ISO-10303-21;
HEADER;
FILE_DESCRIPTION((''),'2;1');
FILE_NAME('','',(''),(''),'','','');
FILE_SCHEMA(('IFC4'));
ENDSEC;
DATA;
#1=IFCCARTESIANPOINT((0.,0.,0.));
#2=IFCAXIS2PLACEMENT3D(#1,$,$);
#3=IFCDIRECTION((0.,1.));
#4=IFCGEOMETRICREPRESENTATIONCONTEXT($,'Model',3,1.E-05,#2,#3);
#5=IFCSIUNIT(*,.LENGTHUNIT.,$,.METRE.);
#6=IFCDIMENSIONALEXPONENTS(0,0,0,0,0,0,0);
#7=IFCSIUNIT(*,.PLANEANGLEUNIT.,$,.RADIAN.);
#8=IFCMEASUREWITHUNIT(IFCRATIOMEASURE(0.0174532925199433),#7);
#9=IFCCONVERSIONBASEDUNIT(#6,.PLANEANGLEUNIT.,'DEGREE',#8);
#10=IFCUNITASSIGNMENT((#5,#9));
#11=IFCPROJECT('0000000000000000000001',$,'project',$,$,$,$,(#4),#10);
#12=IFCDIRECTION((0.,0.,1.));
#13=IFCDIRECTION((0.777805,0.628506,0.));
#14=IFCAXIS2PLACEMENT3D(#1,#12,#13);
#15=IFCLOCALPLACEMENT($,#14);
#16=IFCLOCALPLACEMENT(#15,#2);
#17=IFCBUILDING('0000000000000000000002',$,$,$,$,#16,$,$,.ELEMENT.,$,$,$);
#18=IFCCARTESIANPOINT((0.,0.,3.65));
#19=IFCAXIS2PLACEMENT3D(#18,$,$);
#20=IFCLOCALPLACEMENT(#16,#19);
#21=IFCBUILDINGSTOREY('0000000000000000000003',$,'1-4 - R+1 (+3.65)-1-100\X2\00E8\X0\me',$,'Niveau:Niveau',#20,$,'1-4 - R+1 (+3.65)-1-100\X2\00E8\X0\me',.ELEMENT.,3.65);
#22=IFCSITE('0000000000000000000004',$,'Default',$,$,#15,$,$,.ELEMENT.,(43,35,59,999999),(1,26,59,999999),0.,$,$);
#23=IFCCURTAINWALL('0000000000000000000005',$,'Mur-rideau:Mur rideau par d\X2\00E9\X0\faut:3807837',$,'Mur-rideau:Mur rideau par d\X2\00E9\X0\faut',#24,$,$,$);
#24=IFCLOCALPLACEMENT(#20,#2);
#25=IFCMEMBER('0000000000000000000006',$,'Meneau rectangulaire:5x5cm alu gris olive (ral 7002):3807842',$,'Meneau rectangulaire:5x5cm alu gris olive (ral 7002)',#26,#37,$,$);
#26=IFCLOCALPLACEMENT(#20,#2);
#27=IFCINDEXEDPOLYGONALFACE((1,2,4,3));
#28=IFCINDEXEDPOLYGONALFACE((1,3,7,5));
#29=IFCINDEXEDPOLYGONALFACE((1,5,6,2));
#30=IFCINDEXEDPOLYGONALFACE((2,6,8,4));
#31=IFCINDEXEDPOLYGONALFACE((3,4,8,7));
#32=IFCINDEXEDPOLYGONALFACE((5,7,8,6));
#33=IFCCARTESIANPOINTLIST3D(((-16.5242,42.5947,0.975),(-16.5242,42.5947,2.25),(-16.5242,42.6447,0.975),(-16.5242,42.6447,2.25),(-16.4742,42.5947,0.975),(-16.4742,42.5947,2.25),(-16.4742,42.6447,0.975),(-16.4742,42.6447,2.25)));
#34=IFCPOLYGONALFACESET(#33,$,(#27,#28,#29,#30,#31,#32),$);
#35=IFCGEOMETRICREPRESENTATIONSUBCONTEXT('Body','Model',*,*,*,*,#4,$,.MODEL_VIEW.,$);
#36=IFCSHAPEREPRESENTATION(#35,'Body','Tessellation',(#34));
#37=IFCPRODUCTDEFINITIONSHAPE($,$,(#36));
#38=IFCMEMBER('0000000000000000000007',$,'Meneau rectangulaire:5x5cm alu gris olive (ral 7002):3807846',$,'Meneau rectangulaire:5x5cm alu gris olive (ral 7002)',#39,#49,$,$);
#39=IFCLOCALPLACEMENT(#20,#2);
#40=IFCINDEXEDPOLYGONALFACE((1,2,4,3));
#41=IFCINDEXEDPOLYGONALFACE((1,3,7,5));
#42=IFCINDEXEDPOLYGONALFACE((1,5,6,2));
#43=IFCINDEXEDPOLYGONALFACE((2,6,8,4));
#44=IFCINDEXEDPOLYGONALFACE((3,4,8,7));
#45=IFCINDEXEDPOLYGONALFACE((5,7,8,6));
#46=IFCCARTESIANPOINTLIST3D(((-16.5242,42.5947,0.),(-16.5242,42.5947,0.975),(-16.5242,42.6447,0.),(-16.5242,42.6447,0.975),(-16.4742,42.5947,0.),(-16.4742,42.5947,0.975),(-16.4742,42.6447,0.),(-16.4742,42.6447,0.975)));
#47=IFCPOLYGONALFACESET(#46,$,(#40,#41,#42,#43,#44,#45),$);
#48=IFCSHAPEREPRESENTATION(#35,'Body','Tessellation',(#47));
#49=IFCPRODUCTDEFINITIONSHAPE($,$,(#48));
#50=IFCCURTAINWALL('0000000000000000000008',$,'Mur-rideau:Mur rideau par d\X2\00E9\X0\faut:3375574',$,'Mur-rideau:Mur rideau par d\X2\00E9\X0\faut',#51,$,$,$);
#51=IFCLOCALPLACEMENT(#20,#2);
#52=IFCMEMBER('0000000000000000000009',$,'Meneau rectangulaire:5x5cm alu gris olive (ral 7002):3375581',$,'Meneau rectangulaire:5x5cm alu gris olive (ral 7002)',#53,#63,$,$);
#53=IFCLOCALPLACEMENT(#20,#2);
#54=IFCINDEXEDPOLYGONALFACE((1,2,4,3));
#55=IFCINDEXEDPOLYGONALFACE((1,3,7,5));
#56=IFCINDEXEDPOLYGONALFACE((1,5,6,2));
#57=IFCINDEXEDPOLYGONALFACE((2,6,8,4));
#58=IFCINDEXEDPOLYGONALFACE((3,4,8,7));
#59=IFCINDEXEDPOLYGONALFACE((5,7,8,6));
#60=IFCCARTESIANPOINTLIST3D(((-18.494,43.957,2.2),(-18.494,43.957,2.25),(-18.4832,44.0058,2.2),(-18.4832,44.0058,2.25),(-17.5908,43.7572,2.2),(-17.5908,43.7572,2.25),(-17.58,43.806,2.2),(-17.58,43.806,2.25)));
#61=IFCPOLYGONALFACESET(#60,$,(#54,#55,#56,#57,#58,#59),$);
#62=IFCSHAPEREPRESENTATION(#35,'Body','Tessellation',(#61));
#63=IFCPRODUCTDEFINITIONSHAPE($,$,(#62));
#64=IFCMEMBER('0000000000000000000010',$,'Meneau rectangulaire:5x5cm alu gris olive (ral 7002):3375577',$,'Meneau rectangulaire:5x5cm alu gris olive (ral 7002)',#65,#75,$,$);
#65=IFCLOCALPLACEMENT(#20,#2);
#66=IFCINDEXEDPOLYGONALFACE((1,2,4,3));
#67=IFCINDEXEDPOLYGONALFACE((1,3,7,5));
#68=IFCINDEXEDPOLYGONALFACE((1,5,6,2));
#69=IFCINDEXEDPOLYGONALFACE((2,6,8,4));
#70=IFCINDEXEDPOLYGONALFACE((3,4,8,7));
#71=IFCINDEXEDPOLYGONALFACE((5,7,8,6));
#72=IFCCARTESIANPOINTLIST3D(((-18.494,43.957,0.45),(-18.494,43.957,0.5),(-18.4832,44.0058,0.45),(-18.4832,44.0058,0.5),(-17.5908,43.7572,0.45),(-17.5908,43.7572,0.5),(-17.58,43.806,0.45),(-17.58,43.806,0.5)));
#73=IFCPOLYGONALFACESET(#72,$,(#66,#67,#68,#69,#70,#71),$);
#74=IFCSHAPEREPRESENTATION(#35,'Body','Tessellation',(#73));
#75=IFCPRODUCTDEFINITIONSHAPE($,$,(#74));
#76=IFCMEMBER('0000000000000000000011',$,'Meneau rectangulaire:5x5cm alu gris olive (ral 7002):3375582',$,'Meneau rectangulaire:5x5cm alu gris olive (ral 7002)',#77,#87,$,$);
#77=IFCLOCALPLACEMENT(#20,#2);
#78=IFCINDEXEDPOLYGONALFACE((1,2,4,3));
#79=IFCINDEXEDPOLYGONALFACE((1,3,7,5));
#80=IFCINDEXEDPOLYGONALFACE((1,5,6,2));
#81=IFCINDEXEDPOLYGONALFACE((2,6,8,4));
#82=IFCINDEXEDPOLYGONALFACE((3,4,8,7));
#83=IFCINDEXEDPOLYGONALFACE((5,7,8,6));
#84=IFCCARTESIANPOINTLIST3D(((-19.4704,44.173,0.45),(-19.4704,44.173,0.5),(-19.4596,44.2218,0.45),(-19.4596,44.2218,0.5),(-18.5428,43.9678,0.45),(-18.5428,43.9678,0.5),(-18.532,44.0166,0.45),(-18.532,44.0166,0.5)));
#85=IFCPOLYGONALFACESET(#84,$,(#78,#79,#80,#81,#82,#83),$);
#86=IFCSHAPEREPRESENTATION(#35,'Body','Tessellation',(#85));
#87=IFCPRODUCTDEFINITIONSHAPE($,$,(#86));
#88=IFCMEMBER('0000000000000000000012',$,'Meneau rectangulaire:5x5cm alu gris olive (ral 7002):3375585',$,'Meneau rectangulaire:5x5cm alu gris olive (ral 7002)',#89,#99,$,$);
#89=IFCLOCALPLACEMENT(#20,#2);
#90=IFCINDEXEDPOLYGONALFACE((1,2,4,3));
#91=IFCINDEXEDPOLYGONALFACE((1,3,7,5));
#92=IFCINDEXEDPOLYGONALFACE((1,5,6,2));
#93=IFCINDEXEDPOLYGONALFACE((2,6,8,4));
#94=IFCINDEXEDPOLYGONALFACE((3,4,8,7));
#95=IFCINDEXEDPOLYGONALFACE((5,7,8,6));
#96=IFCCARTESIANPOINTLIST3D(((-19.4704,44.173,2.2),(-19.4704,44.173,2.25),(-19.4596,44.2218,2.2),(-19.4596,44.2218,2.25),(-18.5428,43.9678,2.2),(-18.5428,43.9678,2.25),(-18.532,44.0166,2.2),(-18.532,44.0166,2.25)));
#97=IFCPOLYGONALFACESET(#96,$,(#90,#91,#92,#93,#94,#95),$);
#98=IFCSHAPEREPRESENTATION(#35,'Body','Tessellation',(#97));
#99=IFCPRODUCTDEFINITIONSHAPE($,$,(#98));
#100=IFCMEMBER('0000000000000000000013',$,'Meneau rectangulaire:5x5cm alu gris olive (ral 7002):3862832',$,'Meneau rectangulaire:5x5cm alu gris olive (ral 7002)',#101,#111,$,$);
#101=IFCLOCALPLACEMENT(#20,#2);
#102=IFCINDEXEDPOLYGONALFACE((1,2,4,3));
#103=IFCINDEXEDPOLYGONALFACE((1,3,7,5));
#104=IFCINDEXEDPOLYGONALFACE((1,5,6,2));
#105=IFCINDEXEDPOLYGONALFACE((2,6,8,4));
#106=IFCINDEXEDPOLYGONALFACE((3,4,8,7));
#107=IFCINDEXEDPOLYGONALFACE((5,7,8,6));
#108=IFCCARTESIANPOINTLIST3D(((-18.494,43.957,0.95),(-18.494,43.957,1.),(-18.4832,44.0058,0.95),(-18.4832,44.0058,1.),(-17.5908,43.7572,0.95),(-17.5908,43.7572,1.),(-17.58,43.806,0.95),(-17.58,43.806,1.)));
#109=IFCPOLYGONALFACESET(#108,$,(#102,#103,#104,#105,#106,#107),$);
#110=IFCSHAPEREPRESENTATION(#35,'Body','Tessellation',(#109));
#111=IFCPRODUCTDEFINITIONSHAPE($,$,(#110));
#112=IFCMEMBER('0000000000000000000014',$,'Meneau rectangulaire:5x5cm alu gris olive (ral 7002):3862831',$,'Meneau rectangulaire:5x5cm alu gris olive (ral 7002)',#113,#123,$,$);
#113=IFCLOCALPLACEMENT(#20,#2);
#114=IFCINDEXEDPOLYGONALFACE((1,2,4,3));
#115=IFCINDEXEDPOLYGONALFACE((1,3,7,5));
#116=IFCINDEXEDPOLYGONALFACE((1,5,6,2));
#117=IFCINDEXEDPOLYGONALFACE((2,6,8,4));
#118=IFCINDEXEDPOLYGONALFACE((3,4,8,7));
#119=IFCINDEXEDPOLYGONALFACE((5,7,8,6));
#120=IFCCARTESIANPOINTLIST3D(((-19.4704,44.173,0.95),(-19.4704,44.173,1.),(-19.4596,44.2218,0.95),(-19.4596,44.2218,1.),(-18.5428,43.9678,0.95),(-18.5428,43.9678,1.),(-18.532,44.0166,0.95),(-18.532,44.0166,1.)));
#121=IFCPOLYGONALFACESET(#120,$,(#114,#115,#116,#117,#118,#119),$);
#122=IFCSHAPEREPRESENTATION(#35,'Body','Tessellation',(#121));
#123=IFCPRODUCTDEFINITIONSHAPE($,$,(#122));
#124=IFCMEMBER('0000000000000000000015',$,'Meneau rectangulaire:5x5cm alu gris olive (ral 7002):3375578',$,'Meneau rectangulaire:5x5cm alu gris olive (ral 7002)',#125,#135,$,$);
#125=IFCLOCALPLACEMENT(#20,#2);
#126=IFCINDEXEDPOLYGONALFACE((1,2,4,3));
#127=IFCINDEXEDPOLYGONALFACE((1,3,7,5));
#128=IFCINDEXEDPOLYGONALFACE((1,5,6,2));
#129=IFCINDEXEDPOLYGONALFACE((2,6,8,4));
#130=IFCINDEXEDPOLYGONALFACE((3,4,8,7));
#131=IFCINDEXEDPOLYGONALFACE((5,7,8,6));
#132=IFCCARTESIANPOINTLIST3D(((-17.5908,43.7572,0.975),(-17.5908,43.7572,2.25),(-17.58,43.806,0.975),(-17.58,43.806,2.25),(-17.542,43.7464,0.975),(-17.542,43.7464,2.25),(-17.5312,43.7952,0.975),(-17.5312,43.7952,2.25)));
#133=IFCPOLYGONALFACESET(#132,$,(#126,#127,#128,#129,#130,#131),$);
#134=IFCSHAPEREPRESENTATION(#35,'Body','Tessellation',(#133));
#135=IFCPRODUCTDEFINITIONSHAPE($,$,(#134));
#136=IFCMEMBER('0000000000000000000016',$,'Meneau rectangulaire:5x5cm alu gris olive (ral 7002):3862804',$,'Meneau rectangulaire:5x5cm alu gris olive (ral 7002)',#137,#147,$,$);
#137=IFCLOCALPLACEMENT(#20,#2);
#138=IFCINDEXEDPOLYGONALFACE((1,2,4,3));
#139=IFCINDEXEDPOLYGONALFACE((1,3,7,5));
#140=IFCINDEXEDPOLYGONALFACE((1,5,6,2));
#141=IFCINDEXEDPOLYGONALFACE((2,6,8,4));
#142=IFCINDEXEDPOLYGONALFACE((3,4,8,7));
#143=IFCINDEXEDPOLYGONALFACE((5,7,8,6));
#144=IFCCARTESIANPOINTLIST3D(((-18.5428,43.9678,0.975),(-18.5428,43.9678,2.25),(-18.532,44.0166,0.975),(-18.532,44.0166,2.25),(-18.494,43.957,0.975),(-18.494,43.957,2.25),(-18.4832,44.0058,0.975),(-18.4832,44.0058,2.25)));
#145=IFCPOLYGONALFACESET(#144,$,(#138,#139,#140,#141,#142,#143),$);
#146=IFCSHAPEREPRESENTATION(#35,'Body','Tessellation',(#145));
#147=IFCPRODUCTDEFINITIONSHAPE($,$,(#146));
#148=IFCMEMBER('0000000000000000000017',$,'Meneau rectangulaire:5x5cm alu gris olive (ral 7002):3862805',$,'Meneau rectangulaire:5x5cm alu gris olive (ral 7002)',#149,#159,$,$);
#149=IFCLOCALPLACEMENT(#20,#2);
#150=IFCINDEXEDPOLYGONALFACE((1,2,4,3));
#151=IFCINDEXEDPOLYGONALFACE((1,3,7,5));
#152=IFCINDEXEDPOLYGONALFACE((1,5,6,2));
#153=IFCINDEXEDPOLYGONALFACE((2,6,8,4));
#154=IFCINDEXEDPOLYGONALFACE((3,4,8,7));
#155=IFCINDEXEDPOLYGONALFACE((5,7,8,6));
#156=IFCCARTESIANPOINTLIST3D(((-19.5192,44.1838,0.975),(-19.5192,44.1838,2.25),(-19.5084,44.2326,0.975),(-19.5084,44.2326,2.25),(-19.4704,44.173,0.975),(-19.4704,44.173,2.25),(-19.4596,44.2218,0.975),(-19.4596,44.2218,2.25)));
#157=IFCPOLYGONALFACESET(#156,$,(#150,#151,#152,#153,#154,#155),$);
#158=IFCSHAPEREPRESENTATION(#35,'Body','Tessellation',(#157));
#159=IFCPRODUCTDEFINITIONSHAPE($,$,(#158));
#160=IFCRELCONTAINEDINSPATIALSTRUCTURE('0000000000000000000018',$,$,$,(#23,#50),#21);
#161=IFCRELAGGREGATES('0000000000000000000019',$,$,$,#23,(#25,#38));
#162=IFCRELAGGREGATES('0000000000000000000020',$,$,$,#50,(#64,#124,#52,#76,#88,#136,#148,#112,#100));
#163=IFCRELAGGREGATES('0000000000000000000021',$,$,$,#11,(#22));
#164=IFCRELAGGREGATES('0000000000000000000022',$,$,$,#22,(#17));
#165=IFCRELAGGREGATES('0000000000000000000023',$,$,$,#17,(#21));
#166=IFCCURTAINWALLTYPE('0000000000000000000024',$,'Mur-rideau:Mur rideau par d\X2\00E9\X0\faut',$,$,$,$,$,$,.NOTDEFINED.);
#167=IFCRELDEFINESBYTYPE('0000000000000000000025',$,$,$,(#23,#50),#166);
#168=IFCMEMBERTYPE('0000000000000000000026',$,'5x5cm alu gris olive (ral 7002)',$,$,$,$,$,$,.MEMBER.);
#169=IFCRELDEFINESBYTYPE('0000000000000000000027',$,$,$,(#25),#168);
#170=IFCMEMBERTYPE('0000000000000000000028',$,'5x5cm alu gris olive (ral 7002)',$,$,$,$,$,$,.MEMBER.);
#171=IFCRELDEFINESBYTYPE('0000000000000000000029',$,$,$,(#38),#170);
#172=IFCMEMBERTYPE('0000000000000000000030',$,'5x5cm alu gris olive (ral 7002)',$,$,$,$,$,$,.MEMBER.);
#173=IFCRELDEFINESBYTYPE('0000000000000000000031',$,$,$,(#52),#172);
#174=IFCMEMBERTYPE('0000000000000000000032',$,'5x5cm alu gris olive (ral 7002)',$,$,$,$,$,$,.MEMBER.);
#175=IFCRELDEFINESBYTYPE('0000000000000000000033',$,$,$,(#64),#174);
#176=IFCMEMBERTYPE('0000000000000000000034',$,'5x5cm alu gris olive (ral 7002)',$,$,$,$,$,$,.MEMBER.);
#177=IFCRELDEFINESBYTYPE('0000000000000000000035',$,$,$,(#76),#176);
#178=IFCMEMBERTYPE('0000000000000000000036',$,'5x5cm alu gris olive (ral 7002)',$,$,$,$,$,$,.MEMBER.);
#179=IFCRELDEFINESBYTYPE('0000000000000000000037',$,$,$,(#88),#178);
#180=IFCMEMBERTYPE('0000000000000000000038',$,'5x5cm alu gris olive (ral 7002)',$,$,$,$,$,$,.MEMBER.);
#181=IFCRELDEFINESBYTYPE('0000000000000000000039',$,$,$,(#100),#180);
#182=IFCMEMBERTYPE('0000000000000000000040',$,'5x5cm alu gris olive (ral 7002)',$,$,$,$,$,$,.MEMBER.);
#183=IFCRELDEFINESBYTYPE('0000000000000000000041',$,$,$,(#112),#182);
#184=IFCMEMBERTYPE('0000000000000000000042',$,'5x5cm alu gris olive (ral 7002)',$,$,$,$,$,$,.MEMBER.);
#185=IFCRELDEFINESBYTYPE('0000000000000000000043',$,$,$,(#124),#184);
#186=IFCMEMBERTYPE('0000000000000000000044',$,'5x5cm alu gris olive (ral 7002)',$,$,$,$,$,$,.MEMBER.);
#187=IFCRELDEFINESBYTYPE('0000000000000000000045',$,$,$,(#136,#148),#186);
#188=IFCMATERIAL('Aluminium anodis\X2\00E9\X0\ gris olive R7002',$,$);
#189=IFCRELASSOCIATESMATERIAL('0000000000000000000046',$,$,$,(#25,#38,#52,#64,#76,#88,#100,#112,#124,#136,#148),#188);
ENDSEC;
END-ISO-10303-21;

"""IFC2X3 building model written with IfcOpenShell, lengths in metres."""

from ifc_helpers import new_model, entity, si_unit, converted_unit, direction, frame, origin, origin_2d_with_axis, place, context, subcontext, project, spatial, rectangle, extrude, source, transform, mapped, material, type_object, type_shapes, element, aggregate, save


model = new_model("IFC2X3")

# Units and contexts
model_context = context("Model", 3, precision=1e-05, world=origin(), true_north=direction((0.0, 1.0)))
body_context = subcontext(model_context, "Body", "Model", "MODEL_VIEW")
ifc_project = project(units=[si_unit("LENGTHUNIT", "METRE"), converted_unit("PLANEANGLEUNIT", "DEGREE", entity("IfcRatioMeasure", 0.0174532925199433), si_unit("PLANEANGLEUNIT", "RADIAN"), dimensions=[0, 0, 0, 0, 0, 0, 0])], contexts=[model_context])

# Site, building, storey
site_placement = place(None, frame((0.0, 0.0, 0.0), z_axis=(0.0, 0.0, 1.0), x_axis=(0.777805, 0.628506, 0.0)))
site = spatial("IfcSite", under=ifc_project, at=site_placement, Name="Default", CompositionType="ELEMENT", RefLatitude=(43, 35, 59, 999999), RefLongitude=(1, 26, 59, 999999), RefElevation=0.0)
building_placement = place(site_placement, origin())
building = spatial("IfcBuilding", under=site, at=building_placement, CompositionType="ELEMENT")
storey_placement = place(building_placement, frame((0.0, 0.0, 3.65)))
storey = spatial("IfcBuildingStorey", under=building, at=storey_placement, Name="1-4 - R+1 (+3.65)-1-100ème", ObjectType="Niveau:Niveau", LongName="1-4 - R+1 (+3.65)-1-100ème", CompositionType="ELEMENT", Elevation=3.65)

# Curtain wall, members
curtain_wall_type = type_object("IfcCurtainWallType", Name="Mur-rideau:Mur rideau par défaut", PredefinedType="NOTDEFINED")
curtain_wall_1_placement = place(storey_placement, frame((0.0, 0.0, -3.65)))
curtain_wall_1 = element("IfcCurtainWall", 1, at=curtain_wall_1_placement, inside=storey, type_object=curtain_wall_type, Name="Mur-rideau:Mur rideau par défaut:3807837", ObjectType="Mur-rideau:Mur rideau par défaut")
ifc_material_1 = material(Name="Aluminium anodisé gris olive R7002")
member_type_1 = type_object("IfcMemberType", Name="5x5cm alu gris olive (ral 7002)", PredefinedType="MEMBER")
shared_shape_1 = source(origin(), body_context, "Body", "SweptSolid", [
    extrude(rectangle(XDim=0.05, YDim=0.05, at=origin_2d_with_axis()), frame((-0.025, 0.0, -1.275), z_axis=(0.0, 0.0, 1.0), x_axis=(0.0, -1.0, 0.0)), (0.0, 0.0, 1.0), 1.275),
])
type_shapes(member_type_1, [shared_shape_1])
member_1_placement = place(storey_placement, frame((-16.4992, 42.6447, 2.25), z_axis=(0.0, 0.0, 1.0), x_axis=(0.0, 1.0, 0.0)))
member_1 = element("IfcMember", 2, at=member_1_placement, type_object=member_type_1, material=ifc_material_1, Name="Meneau rectangulaire:5x5cm alu gris olive (ral 7002):3807842", ObjectType="Meneau rectangulaire:5x5cm alu gris olive (ral 7002)", context=body_context, shape_type="MappedRepresentation", body=[
    mapped(shared_shape_1, transform((0.0, 0.0, 0.0), scale=1.0)),
])
member_type_2 = type_object("IfcMemberType", Name="5x5cm alu gris olive (ral 7002)", PredefinedType="MEMBER")
shared_shape_2 = source(origin(), body_context, "Body", "SweptSolid", [
    extrude(rectangle(XDim=0.05, YDim=0.05, at=origin_2d_with_axis()), frame((-0.025, 0.0, -0.975), z_axis=(0.0, 0.0, 1.0), x_axis=(0.0, -1.0, 0.0)), (0.0, 0.0, 1.0), 0.975),
])
type_shapes(member_type_2, [shared_shape_2])
member_2_placement = place(storey_placement, frame((-16.4992, 42.6447, 0.975), z_axis=(0.0, 0.0, 1.0), x_axis=(0.0, 1.0, 0.0)))
member_2 = element("IfcMember", 3, at=member_2_placement, type_object=member_type_2, material=ifc_material_1, Name="Meneau rectangulaire:5x5cm alu gris olive (ral 7002):3807846", ObjectType="Meneau rectangulaire:5x5cm alu gris olive (ral 7002)", context=body_context, shape_type="MappedRepresentation", body=[
    mapped(shared_shape_2, transform((0.0, 0.0, 0.0), scale=1.0)),
])
aggregate(curtain_wall_1, [member_1, member_2])

# Curtain wall, members
curtain_wall_2_placement = place(storey_placement, frame((0.0, 0.0, -3.65)))
curtain_wall_2 = element("IfcCurtainWall", 4, at=curtain_wall_2_placement, inside=storey, type_object=curtain_wall_type, Name="Mur-rideau:Mur rideau par défaut:3375574", ObjectType="Mur-rideau:Mur rideau par défaut")
member_type_3 = type_object("IfcMemberType", Name="5x5cm alu gris olive (ral 7002)", PredefinedType="MEMBER")
shared_shape_3 = source(origin(), body_context, "Body", "SweptSolid", [
    extrude(rectangle(XDim=0.05, YDim=0.05, at=origin_2d_with_axis()), frame((-0.025, 0.0, -0.925), z_axis=(0.0, 0.0, 1.0), x_axis=(0.0, -1.0, 0.0)), (0.0, 0.0, 1.0), 0.925),
])
type_shapes(member_type_3, [shared_shape_3])
member_3_placement = place(storey_placement, frame((-18.4886, 43.9814, 2.25), z_axis=(-0.976392, 0.216005, 0.0), x_axis=(0.0, 0.0, 1.0)))
member_3 = element("IfcMember", 5, at=member_3_placement, type_object=member_type_3, material=ifc_material_1, Name="Meneau rectangulaire:5x5cm alu gris olive (ral 7002):3375581", ObjectType="Meneau rectangulaire:5x5cm alu gris olive (ral 7002)", context=body_context, shape_type="MappedRepresentation", body=[
    mapped(shared_shape_3, transform((0.0, 0.0, 0.0), scale=1.0)),
])
member_type_4 = type_object("IfcMemberType", Name="5x5cm alu gris olive (ral 7002)", PredefinedType="MEMBER")
shared_shape_4 = source(origin(), body_context, "Body", "SweptSolid", [
    extrude(rectangle(XDim=0.05, YDim=0.05, at=origin_2d_with_axis()), frame((-0.025, 0.0, -0.925), z_axis=(0.0, 0.0, 1.0), x_axis=(0.0, -1.0, 0.0)), (0.0, 0.0, 1.0), 0.925),
])
type_shapes(member_type_4, [shared_shape_4])
member_4_placement = place(storey_placement, frame((-17.5854, 43.7816, 0.45), z_axis=(0.976392, -0.216005, 0.0), x_axis=(0.0, 0.0, -1.0)))
member_4 = element("IfcMember", 6, at=member_4_placement, type_object=member_type_4, material=ifc_material_1, Name="Meneau rectangulaire:5x5cm alu gris olive (ral 7002):3375577", ObjectType="Meneau rectangulaire:5x5cm alu gris olive (ral 7002)", context=body_context, shape_type="MappedRepresentation", body=[
    mapped(shared_shape_4, transform((0.0, 0.0, 0.0), scale=1.0)),
])
member_type_5 = type_object("IfcMemberType", Name="5x5cm alu gris olive (ral 7002)", PredefinedType="MEMBER")
shared_shape_5 = source(origin(), body_context, "Body", "SweptSolid", [
    extrude(rectangle(XDim=0.05, YDim=0.05, at=origin_2d_with_axis()), frame((-0.025, 0.0, -0.95), z_axis=(0.0, 0.0, 1.0), x_axis=(0.0, -1.0, 0.0)), (0.0, 0.0, 1.0), 0.95),
])
type_shapes(member_type_5, [shared_shape_5])
member_5_placement = place(storey_placement, frame((-18.5374, 43.9922, 0.45), z_axis=(0.976392, -0.216005, 0.0), x_axis=(0.0, 0.0, -1.0)))
member_5 = element("IfcMember", 7, at=member_5_placement, type_object=member_type_5, material=ifc_material_1, Name="Meneau rectangulaire:5x5cm alu gris olive (ral 7002):3375582", ObjectType="Meneau rectangulaire:5x5cm alu gris olive (ral 7002)", context=body_context, shape_type="MappedRepresentation", body=[
    mapped(shared_shape_5, transform((0.0, 0.0, 0.0), scale=1.0)),
])
member_type_6 = type_object("IfcMemberType", Name="5x5cm alu gris olive (ral 7002)", PredefinedType="MEMBER")
shared_shape_6 = source(origin(), body_context, "Body", "SweptSolid", [
    extrude(rectangle(XDim=0.05, YDim=0.05, at=origin_2d_with_axis()), frame((-0.025, 0.0, -0.95), z_axis=(0.0, 0.0, 1.0), x_axis=(0.0, -1.0, 0.0)), (0.0, 0.0, 1.0), 0.95),
])
type_shapes(member_type_6, [shared_shape_6])
member_6_placement = place(storey_placement, frame((-19.465, 44.1974, 2.25), z_axis=(-0.976392, 0.216005, 0.0), x_axis=(0.0, 0.0, 1.0)))
member_6 = element("IfcMember", 8, at=member_6_placement, type_object=member_type_6, material=ifc_material_1, Name="Meneau rectangulaire:5x5cm alu gris olive (ral 7002):3375585", ObjectType="Meneau rectangulaire:5x5cm alu gris olive (ral 7002)", context=body_context, shape_type="MappedRepresentation", body=[
    mapped(shared_shape_6, transform((0.0, 0.0, 0.0), scale=1.0)),
])
member_type_7 = type_object("IfcMemberType", Name="5x5cm alu gris olive (ral 7002)", PredefinedType="MEMBER")
shared_shape_7 = source(origin(), body_context, "Body", "SweptSolid", [
    extrude(rectangle(XDim=0.05, YDim=0.05, at=origin_2d_with_axis()), frame((0.0, 0.0, -0.925), z_axis=(0.0, 0.0, 1.0), x_axis=(0.0, -1.0, 0.0)), (0.0, 0.0, 1.0), 0.925),
])
type_shapes(member_type_7, [shared_shape_7])
member_7_placement = place(storey_placement, frame((-18.4886, 43.9814, 0.975), z_axis=(-0.976392, 0.216005, 0.0), x_axis=(0.0, 0.0, 1.0)))
member_7 = element("IfcMember", 9, at=member_7_placement, type_object=member_type_7, material=ifc_material_1, Name="Meneau rectangulaire:5x5cm alu gris olive (ral 7002):3862832", ObjectType="Meneau rectangulaire:5x5cm alu gris olive (ral 7002)", context=body_context, shape_type="MappedRepresentation", body=[
    mapped(shared_shape_7, transform((0.0, 0.0, 0.0), scale=1.0)),
])
member_type_8 = type_object("IfcMemberType", Name="5x5cm alu gris olive (ral 7002)", PredefinedType="MEMBER")
shared_shape_8 = source(origin(), body_context, "Body", "SweptSolid", [
    extrude(rectangle(XDim=0.05, YDim=0.05, at=origin_2d_with_axis()), frame((0.0, 0.0, -0.95), z_axis=(0.0, 0.0, 1.0), x_axis=(0.0, -1.0, 0.0)), (0.0, 0.0, 1.0), 0.95),
])
type_shapes(member_type_8, [shared_shape_8])
member_8_placement = place(storey_placement, frame((-19.465, 44.1974, 0.975), z_axis=(-0.976392, 0.216005, 0.0), x_axis=(0.0, 0.0, 1.0)))
member_8 = element("IfcMember", 10, at=member_8_placement, type_object=member_type_8, material=ifc_material_1, Name="Meneau rectangulaire:5x5cm alu gris olive (ral 7002):3862831", ObjectType="Meneau rectangulaire:5x5cm alu gris olive (ral 7002)", context=body_context, shape_type="MappedRepresentation", body=[
    mapped(shared_shape_8, transform((0.0, 0.0, 0.0), scale=1.0)),
])
member_type_9 = type_object("IfcMemberType", Name="5x5cm alu gris olive (ral 7002)", PredefinedType="MEMBER")
shared_shape_9 = source(origin(), body_context, "Body", "SweptSolid", [
    extrude(rectangle(XDim=0.05, YDim=0.05, at=origin_2d_with_axis()), frame((-0.025, 0.0, -1.275), z_axis=(0.0, 0.0, 1.0), x_axis=(0.0, -1.0, 0.0)), (0.0, 0.0, 1.0), 1.275),
])
type_shapes(member_type_9, [shared_shape_9])
member_9_placement = place(storey_placement, frame((-17.5366, 43.7708, 2.25), z_axis=(0.0, 0.0, 1.0), x_axis=(0.976392, -0.216005, 0.0)))
member_9 = element("IfcMember", 11, at=member_9_placement, type_object=member_type_9, material=ifc_material_1, Name="Meneau rectangulaire:5x5cm alu gris olive (ral 7002):3375578", ObjectType="Meneau rectangulaire:5x5cm alu gris olive (ral 7002)", context=body_context, shape_type="MappedRepresentation", body=[
    mapped(shared_shape_9, transform((0.0, 0.0, 0.0), scale=1.0)),
])
member_type_10 = type_object("IfcMemberType", Name="5x5cm alu gris olive (ral 7002)", PredefinedType="MEMBER")
shared_shape_10 = source(origin(), body_context, "Body", "SweptSolid", [
    extrude(rectangle(XDim=0.05, YDim=0.05, at=origin_2d_with_axis()), frame((0.0, 0.0, -1.275), z_axis=(0.0, 0.0, 1.0), x_axis=(0.0, -1.0, 0.0)), (0.0, 0.0, 1.0), 1.275),
])
type_shapes(member_type_10, [shared_shape_10])
member_10_placement = place(storey_placement, frame((-18.513, 43.9868, 0.975), z_axis=(0.0, 0.0, -1.0), x_axis=(-0.976392, 0.216005, 0.0)))
member_10 = element("IfcMember", 12, at=member_10_placement, type_object=member_type_10, material=ifc_material_1, Name="Meneau rectangulaire:5x5cm alu gris olive (ral 7002):3862804", ObjectType="Meneau rectangulaire:5x5cm alu gris olive (ral 7002)", context=body_context, shape_type="MappedRepresentation", body=[
    mapped(shared_shape_10, transform((0.0, 0.0, 0.0), scale=1.0)),
])
member_11_placement = place(storey_placement, frame((-19.4894, 44.2028, 0.975), z_axis=(0.0, 0.0, -1.0), x_axis=(-0.976392, 0.216005, 0.0)))
member_11 = element("IfcMember", 13, at=member_11_placement, type_object=member_type_10, material=ifc_material_1, Name="Meneau rectangulaire:5x5cm alu gris olive (ral 7002):3862805", ObjectType="Meneau rectangulaire:5x5cm alu gris olive (ral 7002)", context=body_context, shape_type="MappedRepresentation", body=[
    mapped(shared_shape_10, transform((0.0, 0.0, 0.0), scale=1.0)),
])
aggregate(curtain_wall_2, [member_4, member_9, member_3, member_5, member_6, member_10, member_11, member_8, member_7])

save(model, "model.ifc")
